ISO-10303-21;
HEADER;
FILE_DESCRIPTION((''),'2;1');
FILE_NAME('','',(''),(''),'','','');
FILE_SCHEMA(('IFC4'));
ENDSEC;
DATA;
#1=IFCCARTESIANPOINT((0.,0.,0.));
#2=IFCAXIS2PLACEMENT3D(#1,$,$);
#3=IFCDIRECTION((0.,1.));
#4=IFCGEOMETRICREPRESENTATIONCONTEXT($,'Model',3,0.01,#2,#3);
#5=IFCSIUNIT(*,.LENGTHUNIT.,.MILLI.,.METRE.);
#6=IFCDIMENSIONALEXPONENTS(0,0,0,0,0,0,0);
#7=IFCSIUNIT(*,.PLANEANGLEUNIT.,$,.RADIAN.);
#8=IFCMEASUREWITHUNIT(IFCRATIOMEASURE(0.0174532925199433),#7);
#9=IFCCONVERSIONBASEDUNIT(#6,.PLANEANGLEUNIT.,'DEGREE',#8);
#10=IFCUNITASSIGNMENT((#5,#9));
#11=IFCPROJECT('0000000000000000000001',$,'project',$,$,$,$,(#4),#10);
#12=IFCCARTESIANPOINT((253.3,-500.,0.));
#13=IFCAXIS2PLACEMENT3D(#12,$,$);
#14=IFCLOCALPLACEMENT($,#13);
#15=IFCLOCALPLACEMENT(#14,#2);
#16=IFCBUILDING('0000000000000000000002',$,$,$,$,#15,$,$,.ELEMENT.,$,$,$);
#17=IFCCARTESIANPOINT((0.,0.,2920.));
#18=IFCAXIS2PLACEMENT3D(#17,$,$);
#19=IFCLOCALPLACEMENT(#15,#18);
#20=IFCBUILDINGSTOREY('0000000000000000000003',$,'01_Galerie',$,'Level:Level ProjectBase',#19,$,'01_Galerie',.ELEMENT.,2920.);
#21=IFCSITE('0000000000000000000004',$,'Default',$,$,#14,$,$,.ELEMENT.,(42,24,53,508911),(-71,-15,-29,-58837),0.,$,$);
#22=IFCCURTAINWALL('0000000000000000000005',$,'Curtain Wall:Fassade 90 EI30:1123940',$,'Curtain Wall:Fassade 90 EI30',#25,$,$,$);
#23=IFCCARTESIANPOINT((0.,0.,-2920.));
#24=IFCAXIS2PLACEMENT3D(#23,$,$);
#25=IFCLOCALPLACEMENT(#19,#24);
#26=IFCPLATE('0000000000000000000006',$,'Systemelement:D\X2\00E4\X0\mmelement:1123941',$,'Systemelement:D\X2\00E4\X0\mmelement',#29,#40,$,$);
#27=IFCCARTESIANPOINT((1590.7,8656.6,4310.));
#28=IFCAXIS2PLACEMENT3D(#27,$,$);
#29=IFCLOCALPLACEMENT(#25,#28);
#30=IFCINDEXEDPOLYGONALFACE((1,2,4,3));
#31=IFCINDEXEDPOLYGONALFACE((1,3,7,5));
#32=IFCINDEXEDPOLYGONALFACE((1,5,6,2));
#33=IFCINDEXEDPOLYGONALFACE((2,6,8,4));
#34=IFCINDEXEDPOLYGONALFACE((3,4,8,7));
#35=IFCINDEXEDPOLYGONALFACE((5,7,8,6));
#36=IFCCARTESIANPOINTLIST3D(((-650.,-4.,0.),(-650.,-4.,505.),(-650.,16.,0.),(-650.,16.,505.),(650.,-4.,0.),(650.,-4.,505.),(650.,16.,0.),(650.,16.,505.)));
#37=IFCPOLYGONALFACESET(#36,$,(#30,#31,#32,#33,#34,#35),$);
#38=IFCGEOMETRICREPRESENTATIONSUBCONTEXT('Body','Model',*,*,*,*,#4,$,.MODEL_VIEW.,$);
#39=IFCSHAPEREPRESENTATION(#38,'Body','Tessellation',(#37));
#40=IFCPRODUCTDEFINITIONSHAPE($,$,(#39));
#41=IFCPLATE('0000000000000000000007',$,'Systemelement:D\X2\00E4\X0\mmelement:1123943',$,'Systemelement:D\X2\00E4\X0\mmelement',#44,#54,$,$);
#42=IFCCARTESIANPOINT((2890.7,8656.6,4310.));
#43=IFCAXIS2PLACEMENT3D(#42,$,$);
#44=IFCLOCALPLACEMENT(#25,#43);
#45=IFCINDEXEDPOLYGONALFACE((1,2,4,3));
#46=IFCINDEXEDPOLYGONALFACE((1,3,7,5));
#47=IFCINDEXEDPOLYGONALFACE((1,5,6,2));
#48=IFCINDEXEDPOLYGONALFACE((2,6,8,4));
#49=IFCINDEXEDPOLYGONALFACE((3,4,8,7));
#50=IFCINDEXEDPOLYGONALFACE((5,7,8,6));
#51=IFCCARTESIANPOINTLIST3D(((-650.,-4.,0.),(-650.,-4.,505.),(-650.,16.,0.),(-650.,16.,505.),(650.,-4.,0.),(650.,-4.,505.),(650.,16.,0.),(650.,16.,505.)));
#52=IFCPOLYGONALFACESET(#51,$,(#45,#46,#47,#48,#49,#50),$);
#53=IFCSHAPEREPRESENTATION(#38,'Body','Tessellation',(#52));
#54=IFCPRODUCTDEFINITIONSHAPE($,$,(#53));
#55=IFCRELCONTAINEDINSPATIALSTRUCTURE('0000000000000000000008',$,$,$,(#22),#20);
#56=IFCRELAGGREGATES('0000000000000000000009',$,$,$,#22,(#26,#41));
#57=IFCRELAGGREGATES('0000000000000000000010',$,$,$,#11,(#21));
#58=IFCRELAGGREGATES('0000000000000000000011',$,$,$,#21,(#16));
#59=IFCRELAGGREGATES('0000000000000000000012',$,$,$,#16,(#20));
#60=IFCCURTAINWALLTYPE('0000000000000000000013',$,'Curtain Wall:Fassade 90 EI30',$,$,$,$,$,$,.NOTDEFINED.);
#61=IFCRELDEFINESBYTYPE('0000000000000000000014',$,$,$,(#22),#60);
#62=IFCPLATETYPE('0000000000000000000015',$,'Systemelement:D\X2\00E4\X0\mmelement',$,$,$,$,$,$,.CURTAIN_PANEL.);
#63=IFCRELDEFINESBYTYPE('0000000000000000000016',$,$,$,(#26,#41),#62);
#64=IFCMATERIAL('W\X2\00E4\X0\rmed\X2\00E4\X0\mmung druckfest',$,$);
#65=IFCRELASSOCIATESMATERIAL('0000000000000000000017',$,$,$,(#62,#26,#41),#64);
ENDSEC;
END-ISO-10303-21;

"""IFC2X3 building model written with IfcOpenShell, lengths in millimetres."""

from ifc_helpers import new_model, entity, si_unit, converted_unit, direction, frame, origin, origin_2d_with_axis, place, context, subcontext, project, spatial, rectangle, extrude, source, transform, mapped, material, type_object, type_shapes, element, aggregate, save


model = new_model("IFC2X3")

# Units and contexts
model_context = context("Model", 3, precision=0.01, world=origin(), true_north=direction((0.0, 1.0)))
body_context = subcontext(model_context, "Body", "Model", "MODEL_VIEW")
ifc_project = project(units=[si_unit("LENGTHUNIT", "METRE", prefix="MILLI"), converted_unit("PLANEANGLEUNIT", "DEGREE", entity("IfcRatioMeasure", 0.0174532925199433), si_unit("PLANEANGLEUNIT", "RADIAN"), dimensions=[0, 0, 0, 0, 0, 0, 0])], contexts=[model_context])

# Site, building, storey
site_placement = place(None, frame((253.3, -500.0, 0.0)))
site = spatial("IfcSite", under=ifc_project, at=site_placement, Name="Default", CompositionType="ELEMENT", RefLatitude=(42, 24, 53, 508911), RefLongitude=(-71, -15, -29, -58837), RefElevation=0.0)
building_placement = place(site_placement, origin())
building = spatial("IfcBuilding", under=site, at=building_placement, CompositionType="ELEMENT")
storey_placement = place(building_placement, frame((0.0, 0.0, 2920.0)))
storey = spatial("IfcBuildingStorey", under=building, at=storey_placement, Name="01_Galerie", ObjectType="Level:Level ProjectBase", LongName="01_Galerie", CompositionType="ELEMENT", Elevation=2920.0)

# Curtain wall, plates
curtain_wall_type = type_object("IfcCurtainWallType", Name="Curtain Wall:Fassade 90 EI30", PredefinedType="NOTDEFINED")
curtain_wall_placement = place(storey_placement, frame((0.0, 0.0, -2920.0)))
curtain_wall = element("IfcCurtainWall", 1, at=curtain_wall_placement, inside=storey, type_object=curtain_wall_type, Name="Curtain Wall:Fassade 90 EI30:1123940", ObjectType="Curtain Wall:Fassade 90 EI30")
ifc_material_1 = material(Name="Wärmedämmung druckfest")
plate_type_1 = type_object("IfcPlateType", Name="Systemelement:Dämmelement", PredefinedType="CURTAIN_PANEL", material=ifc_material_1)
shared_shape_1 = source(origin(), body_context, "Body", "SweptSolid", [
    extrude(rectangle(XDim=20.0, YDim=1300.0, at=origin_2d_with_axis()), frame((0.0, 6.0, 0.0), z_axis=(0.0, 0.0, 1.0), x_axis=(0.0, 1.0, 0.0)), (0.0, 0.0, 1.0), 505.0),
])
type_shapes(plate_type_1, [shared_shape_1])
plate_1_placement = place(curtain_wall_placement, frame((1590.7, 8656.6, 4310.0)))
plate_1 = element("IfcPlate", 2, at=plate_1_placement, type_object=plate_type_1, material=ifc_material_1, Name="Systemelement:Dämmelement:1123941", ObjectType="Systemelement:Dämmelement", context=body_context, shape_type="MappedRepresentation", body=[
    mapped(shared_shape_1, transform((0.0, 0.0, 0.0), scale=1.0)),
])
plate_2_placement = place(curtain_wall_placement, frame((2890.7, 8656.6, 4310.0)))
plate_2 = element("IfcPlate", 3, at=plate_2_placement, type_object=plate_type_1, material=ifc_material_1, Name="Systemelement:Dämmelement:1123943", ObjectType="Systemelement:Dämmelement", context=body_context, shape_type="MappedRepresentation", body=[
    mapped(shared_shape_1, transform((0.0, 0.0, 0.0), scale=1.0)),
])
aggregate(curtain_wall, [plate_1, plate_2])

save(model, "model.ifc")
